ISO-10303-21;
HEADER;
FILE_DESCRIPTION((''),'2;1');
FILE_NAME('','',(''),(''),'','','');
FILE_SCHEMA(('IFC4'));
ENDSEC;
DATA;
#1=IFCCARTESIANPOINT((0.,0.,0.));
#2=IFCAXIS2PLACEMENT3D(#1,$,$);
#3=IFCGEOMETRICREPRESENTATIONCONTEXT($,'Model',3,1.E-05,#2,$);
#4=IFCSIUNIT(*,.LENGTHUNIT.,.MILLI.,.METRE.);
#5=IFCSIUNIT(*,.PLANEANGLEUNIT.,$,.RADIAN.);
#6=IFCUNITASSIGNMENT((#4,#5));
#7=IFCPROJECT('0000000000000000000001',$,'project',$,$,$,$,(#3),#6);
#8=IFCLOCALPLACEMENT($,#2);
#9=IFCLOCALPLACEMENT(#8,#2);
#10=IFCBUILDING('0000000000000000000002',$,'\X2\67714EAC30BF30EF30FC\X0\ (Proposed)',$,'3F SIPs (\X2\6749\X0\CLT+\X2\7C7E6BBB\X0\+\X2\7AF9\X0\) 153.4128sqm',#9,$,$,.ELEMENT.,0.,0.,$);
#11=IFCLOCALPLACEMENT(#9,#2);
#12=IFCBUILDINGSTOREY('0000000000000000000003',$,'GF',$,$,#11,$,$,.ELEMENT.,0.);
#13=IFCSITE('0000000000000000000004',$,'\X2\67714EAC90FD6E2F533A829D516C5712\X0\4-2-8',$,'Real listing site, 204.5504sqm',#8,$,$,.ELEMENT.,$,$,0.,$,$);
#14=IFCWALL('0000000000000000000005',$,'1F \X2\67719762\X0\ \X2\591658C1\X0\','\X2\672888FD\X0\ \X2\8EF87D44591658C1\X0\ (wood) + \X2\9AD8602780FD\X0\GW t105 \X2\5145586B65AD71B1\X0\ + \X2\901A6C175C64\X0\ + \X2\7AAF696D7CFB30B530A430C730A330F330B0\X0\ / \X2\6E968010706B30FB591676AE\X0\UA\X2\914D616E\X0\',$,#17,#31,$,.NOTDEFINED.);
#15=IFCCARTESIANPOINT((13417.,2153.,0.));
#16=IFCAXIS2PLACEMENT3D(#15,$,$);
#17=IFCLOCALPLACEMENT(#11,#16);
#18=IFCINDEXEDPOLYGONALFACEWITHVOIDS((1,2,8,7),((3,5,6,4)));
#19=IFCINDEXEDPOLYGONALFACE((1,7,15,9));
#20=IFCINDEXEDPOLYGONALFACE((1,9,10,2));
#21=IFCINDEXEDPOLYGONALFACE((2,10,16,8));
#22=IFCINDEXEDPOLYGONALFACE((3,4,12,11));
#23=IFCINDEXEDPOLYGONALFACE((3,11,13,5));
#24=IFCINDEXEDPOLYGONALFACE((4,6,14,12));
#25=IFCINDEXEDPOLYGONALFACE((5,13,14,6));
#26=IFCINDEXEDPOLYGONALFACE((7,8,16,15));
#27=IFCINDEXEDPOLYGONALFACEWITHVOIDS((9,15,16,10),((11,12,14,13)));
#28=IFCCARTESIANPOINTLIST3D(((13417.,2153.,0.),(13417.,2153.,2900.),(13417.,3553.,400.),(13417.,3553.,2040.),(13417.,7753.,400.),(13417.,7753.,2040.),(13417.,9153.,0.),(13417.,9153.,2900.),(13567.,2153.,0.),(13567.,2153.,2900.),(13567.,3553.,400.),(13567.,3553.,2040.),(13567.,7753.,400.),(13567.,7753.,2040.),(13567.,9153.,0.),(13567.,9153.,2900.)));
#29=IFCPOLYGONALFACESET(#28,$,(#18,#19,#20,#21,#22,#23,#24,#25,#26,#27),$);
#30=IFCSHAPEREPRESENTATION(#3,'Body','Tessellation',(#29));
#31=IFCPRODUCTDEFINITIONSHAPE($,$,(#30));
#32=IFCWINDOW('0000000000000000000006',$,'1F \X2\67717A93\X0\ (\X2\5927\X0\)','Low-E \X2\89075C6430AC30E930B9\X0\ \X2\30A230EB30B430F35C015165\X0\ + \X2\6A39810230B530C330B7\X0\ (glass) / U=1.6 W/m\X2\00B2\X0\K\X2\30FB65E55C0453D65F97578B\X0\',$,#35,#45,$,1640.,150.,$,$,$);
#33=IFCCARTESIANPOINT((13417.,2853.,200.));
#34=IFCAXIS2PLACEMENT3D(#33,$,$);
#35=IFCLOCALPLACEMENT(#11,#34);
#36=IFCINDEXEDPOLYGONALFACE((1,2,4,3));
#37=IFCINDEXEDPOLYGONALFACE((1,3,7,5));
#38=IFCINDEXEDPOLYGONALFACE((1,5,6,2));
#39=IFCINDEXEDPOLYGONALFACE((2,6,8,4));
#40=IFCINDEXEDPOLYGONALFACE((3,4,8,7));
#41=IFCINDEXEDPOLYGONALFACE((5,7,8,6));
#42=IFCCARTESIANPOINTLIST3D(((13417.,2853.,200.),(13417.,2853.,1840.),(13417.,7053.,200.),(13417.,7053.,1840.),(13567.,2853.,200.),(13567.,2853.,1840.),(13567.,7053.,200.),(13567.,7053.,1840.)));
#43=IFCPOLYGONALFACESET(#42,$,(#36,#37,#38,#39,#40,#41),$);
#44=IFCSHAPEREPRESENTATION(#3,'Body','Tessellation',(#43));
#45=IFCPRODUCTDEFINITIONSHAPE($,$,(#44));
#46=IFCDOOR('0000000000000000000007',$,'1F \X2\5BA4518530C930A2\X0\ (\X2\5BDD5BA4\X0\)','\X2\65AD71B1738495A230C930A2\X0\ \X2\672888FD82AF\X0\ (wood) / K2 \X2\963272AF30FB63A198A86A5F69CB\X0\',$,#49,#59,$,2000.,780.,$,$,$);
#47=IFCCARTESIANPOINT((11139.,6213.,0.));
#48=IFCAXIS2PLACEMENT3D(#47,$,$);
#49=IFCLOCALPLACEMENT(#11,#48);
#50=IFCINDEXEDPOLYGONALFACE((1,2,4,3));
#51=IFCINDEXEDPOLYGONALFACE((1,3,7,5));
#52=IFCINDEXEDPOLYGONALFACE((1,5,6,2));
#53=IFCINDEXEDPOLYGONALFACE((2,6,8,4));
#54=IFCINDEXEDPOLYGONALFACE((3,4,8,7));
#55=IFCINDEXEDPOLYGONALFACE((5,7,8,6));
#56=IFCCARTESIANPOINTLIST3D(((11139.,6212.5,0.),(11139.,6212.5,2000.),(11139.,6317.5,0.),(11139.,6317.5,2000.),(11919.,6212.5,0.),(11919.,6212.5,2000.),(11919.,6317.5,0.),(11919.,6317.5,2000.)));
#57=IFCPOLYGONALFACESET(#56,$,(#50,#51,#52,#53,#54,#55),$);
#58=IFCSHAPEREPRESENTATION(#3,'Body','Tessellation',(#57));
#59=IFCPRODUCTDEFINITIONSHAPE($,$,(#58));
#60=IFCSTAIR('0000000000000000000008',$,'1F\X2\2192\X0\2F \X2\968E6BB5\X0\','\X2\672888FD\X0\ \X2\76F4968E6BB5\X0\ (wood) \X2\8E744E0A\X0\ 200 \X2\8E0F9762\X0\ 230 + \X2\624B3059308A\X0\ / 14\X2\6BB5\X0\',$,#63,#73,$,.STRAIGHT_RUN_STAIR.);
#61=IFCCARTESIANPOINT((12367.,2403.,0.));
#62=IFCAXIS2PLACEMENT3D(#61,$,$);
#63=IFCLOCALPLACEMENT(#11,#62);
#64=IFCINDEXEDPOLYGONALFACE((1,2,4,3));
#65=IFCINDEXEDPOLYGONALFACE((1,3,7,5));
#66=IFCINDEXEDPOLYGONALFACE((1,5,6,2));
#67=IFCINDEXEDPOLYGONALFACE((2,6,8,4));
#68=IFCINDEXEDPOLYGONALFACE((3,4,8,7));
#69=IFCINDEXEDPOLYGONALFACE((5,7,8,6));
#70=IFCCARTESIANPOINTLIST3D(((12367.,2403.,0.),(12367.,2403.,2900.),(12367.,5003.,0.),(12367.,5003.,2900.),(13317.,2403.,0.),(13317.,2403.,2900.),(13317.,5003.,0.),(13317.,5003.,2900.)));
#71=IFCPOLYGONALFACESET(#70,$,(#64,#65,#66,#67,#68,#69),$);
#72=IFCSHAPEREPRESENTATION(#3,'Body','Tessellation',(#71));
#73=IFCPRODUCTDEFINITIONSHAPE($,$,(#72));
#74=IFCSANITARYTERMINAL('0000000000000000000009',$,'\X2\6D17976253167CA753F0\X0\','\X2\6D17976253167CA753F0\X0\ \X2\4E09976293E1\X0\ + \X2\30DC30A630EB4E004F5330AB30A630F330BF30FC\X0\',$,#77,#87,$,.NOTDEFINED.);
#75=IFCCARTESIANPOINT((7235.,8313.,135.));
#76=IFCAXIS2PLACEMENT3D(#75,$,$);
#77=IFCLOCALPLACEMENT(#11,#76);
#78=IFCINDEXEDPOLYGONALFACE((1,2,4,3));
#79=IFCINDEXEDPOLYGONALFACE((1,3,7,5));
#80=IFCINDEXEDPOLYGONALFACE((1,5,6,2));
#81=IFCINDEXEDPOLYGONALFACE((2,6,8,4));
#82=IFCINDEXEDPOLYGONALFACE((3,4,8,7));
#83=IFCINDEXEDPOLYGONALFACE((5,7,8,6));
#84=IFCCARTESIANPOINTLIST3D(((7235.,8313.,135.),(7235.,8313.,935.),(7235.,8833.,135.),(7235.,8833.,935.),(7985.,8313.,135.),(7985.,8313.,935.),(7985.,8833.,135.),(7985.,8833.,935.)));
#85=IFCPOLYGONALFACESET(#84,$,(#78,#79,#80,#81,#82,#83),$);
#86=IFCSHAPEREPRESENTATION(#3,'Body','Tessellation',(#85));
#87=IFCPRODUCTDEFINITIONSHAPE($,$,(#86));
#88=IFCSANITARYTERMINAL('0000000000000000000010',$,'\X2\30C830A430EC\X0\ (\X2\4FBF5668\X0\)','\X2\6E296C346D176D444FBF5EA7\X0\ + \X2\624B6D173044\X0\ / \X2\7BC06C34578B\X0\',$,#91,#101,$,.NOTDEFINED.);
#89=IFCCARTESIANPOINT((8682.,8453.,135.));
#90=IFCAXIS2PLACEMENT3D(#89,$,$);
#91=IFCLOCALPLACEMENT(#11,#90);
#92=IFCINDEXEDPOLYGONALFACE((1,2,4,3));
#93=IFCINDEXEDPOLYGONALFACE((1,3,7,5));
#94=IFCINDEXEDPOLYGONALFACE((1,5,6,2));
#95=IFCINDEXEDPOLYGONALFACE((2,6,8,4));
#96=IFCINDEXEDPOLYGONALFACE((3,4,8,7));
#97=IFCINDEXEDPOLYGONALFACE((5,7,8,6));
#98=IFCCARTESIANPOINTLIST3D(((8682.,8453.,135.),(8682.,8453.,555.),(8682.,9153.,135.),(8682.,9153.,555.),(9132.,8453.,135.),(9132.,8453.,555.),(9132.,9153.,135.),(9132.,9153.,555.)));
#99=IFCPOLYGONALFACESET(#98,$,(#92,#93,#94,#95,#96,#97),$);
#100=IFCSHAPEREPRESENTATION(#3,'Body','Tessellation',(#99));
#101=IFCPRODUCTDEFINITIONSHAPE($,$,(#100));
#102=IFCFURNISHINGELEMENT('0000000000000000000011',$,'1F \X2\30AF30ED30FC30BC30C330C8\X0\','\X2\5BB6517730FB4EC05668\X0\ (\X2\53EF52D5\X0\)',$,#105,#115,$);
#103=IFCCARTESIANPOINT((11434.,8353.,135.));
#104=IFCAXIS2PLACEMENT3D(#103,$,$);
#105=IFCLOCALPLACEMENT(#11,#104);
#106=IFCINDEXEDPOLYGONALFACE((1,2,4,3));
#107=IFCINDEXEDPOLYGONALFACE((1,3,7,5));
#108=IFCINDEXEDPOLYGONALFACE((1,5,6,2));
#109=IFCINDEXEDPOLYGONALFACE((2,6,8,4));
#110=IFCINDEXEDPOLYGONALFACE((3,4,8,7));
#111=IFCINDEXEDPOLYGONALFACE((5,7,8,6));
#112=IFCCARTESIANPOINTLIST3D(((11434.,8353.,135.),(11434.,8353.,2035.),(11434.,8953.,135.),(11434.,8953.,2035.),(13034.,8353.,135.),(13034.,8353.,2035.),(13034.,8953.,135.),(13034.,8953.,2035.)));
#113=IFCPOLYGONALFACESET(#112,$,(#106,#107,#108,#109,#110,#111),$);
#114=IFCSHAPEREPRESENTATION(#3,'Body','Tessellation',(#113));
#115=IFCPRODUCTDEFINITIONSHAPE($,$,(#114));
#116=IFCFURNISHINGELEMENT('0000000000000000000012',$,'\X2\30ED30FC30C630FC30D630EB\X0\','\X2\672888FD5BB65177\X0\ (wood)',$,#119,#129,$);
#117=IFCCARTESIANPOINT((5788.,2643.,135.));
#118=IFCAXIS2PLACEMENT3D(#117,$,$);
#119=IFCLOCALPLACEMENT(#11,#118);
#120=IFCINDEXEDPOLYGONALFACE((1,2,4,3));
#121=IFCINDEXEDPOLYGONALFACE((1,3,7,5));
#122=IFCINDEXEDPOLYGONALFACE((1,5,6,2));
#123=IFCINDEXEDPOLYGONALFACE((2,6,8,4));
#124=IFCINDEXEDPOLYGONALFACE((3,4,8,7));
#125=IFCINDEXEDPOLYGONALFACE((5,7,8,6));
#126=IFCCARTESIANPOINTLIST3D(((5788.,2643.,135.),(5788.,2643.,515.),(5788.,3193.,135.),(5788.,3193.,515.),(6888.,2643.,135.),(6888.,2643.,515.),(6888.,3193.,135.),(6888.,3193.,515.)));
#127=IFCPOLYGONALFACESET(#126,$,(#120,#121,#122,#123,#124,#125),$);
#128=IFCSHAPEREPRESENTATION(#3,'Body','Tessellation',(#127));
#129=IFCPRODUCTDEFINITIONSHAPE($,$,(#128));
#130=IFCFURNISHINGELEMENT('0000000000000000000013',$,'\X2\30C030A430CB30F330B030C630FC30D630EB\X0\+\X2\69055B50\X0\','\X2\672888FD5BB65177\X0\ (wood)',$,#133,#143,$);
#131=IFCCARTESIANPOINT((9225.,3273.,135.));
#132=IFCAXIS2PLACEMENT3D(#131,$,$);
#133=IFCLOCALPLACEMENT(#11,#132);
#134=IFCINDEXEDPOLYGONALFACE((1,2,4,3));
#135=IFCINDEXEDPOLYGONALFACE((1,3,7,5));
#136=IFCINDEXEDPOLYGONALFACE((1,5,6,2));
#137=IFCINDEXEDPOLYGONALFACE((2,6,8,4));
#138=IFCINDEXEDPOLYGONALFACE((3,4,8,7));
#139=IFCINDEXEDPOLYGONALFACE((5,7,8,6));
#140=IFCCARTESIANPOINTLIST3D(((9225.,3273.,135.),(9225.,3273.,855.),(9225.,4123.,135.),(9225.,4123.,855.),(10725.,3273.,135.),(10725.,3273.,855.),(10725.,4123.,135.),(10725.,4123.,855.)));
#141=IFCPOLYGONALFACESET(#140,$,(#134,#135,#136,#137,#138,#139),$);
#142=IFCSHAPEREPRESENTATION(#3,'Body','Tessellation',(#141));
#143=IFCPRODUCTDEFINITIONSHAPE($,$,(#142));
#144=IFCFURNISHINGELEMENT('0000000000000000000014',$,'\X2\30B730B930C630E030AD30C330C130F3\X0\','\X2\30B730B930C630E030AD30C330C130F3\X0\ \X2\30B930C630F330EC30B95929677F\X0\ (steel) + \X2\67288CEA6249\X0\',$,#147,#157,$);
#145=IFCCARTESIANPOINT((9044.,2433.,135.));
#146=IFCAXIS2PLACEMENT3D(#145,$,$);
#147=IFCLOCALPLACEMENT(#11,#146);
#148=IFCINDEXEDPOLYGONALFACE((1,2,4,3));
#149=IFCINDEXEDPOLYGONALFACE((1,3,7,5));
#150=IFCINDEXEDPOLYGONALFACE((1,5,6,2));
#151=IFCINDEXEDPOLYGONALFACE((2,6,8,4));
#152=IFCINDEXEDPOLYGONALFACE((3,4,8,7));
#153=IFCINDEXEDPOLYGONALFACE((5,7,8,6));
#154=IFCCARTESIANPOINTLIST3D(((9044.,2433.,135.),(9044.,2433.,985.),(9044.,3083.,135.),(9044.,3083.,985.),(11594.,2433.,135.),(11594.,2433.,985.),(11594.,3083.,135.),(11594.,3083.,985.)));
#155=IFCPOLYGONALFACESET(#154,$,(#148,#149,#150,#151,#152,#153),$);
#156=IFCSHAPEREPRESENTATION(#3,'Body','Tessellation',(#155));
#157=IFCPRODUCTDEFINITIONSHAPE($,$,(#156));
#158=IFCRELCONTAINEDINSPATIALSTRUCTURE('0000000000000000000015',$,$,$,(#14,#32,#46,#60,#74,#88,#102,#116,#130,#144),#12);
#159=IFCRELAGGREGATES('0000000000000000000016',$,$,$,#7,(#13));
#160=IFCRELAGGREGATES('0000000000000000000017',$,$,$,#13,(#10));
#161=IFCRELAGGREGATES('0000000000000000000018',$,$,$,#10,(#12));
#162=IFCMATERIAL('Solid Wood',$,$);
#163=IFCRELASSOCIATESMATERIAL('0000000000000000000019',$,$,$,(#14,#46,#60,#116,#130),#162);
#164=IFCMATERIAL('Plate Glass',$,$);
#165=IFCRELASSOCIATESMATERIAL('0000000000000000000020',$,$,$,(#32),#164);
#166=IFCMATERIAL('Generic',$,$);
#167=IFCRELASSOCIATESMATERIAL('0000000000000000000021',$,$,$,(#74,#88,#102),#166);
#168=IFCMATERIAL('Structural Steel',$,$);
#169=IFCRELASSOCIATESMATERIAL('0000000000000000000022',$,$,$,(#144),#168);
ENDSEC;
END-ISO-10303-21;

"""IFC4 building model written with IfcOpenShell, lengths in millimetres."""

from ifc_helpers import new_model, si_unit, frame, frame_2d, origin, place, context, project, spatial, rectangle, extrude, material, element, fill, save


model = new_model("IFC4")

# Units and contexts
model_context = context("Model", 3, precision=1e-05, world=origin())
ifc_project = project(units=[si_unit("LENGTHUNIT", "METRE", prefix="MILLI"), si_unit("PLANEANGLEUNIT", "RADIAN")], contexts=[model_context])

# Site, building, storey
site_placement = place(None, origin())
site = spatial("IfcSite", under=ifc_project, at=site_placement, Name="東京都港区芝公園4-2-8", ObjectType="Real listing site, 204.5504sqm", CompositionType="ELEMENT", RefElevation=0.0)
building_placement = place(site_placement, origin())
building = spatial("IfcBuilding", under=site, at=building_placement, Name="東京タワー (Proposed)", ObjectType="3F SIPs (杉CLT+籾殻+竹) 153.4128sqm", CompositionType="ELEMENT", ElevationOfRefHeight=0.0, ElevationOfTerrain=0.0)
storey_placement = place(building_placement, origin())
storey = spatial("IfcBuildingStorey", under=building, at=storey_placement, Name="GF", CompositionType="ELEMENT", Elevation=0.0)

# Wall, opening, window
ifc_material_1 = material(Name="Solid Wood")
wall_1_placement = place(storey_placement, frame((13417.0, 2153.0, 0.0)))
wall_1 = element("IfcWall", 1, at=wall_1_placement, inside=storey, material=ifc_material_1, Name="1F 東面 外壁", Description="木製 軸組外壁 (wood) + 高性能GW t105 充填断熱 + 通気層 + 窯業系サイディング / 準耐火・外皮UA配慮", PredefinedType="NOTDEFINED", context=model_context, shape_type="SweptSolid", body=[
    extrude(rectangle(XDim=150.0, YDim=7000.0, at=frame_2d((75.0, 3500.0))), frame((13417.0, 2153.0, 0.0)), (0.0, 0.0, 1.0), 2900.0),
])
opening_placement = place(storey_placement, frame((13417.0, 2853.0, 200.0)))
opening = element("IfcOpeningElement", 2, at=opening_placement, cuts=wall_1, PredefinedType="NOTDEFINED", context=model_context, shape_type="SweptSolid", body=[
    extrude(rectangle(XDim=150.0, YDim=4200.0, at=frame_2d((75.0, 2100.0))), frame((13417.0, 2853.0, 200.0)), (0.0, 0.0, 1.0), 1640.0),
])
ifc_material_2 = material(Name="Plate Glass")
window_placement = place(storey_placement, frame((13417.0, 2853.0, 200.0)))
window = element("IfcWindow", 3, at=window_placement, inside=storey, material=ifc_material_2, Name="1F 東窓 (大)", Description="Low-E 複層ガラス アルゴン封入 + 樹脂サッシ (glass) / U=1.6 W/m²K・日射取得型", OverallHeight=1640.0, OverallWidth=150.0, context=model_context, shape_type="SweptSolid", body=[
    extrude(rectangle(XDim=150.0, YDim=4200.0, at=frame_2d((75.0, 2100.0))), frame((13417.0, 2853.0, 200.0)), (0.0, 0.0, 1.0), 1640.0),
])
fill(opening, window)

# Door
door_placement = place(storey_placement, frame((11139.0, 6213.0, 0.0)))
element("IfcDoor", 4, at=door_placement, inside=storey, material=ifc_material_1, Name="1F 室内ドア (寝室)", Description="断熱玄関ドア 木製芯 (wood) / K2 防犯・採風機構", OverallHeight=2000.0, OverallWidth=780.0, context=model_context, shape_type="SweptSolid", body=[
    extrude(rectangle(XDim=780.0, YDim=105.0, at=frame_2d((390.0, 52.0))), frame((11139.0, 6213.0, 0.0)), (0.0, 0.0, 1.0), 2000.0),
])

# Stair
stair_placement = place(storey_placement, frame((12367.0, 2403.0, 0.0)))
element("IfcStair", 5, at=stair_placement, inside=storey, material=ifc_material_1, Name="1F→2F 階段", Description="木製 直階段 (wood) 蹴上 200 踏面 230 + 手すり / 14段", PredefinedType="STRAIGHT_RUN_STAIR", context=model_context, shape_type="SweptSolid", body=[
    extrude(rectangle(XDim=950.0, YDim=2600.0, at=frame_2d((475.0, 1300.0))), frame((12367.0, 2403.0, 0.0)), (0.0, 0.0, 1.0), 2900.0),
])

# Sanitary terminals
ifc_material_3 = material(Name="Generic")
sanitary_terminal_1_placement = place(storey_placement, frame((7235.0, 8313.0, 135.0)))
element("IfcSanitaryTerminal", 6, at=sanitary_terminal_1_placement, inside=storey, material=ifc_material_3, Name="洗面化粧台", Description="洗面化粧台 三面鏡 + ボウル一体カウンター", PredefinedType="NOTDEFINED", context=model_context, shape_type="SweptSolid", body=[
    extrude(rectangle(XDim=750.0, YDim=520.0, at=frame_2d((375.0, 260.0))), frame((7235.0, 8313.0, 135.0)), (0.0, 0.0, 1.0), 800.0),
])
sanitary_terminal_2_placement = place(storey_placement, frame((8682.0, 8453.0, 135.0)))
element("IfcSanitaryTerminal", 7, at=sanitary_terminal_2_placement, inside=storey, material=ifc_material_3, Name="トイレ (便器)", Description="温水洗浄便座 + 手洗い / 節水型", PredefinedType="NOTDEFINED", context=model_context, shape_type="SweptSolid", body=[
    extrude(rectangle(XDim=450.0, YDim=700.0, at=frame_2d((225.0, 350.0))), frame((8682.0, 8453.0, 135.0)), (0.0, 0.0, 1.0), 420.0),
])

# Furnishing elements
furnishing_1_placement = place(storey_placement, frame((11434.0, 8353.0, 135.0)))
element("IfcFurnishingElement", 8, at=furnishing_1_placement, inside=storey, material=ifc_material_3, Name="1F クローゼット", Description="家具・什器 (可動)", context=model_context, shape_type="SweptSolid", body=[
    extrude(rectangle(XDim=1600.0, YDim=600.0, at=frame_2d((800.0, 300.0))), frame((11434.0, 8353.0, 135.0)), (0.0, 0.0, 1.0), 1900.0),
])
furnishing_2_placement = place(storey_placement, frame((5788.0, 2643.0, 135.0)))
element("IfcFurnishingElement", 9, at=furnishing_2_placement, inside=storey, material=ifc_material_1, Name="ローテーブル", Description="木製家具 (wood)", context=model_context, shape_type="SweptSolid", body=[
    extrude(rectangle(XDim=1100.0, YDim=550.0, at=frame_2d((550.0, 275.0))), frame((5788.0, 2643.0, 135.0)), (0.0, 0.0, 1.0), 380.0),
])
furnishing_3_placement = place(storey_placement, frame((9225.0, 3273.0, 135.0)))
element("IfcFurnishingElement", 10, at=furnishing_3_placement, inside=storey, material=ifc_material_1, Name="ダイニングテーブル+椅子", Description="木製家具 (wood)", context=model_context, shape_type="SweptSolid", body=[
    extrude(rectangle(XDim=1500.0, YDim=850.0, at=frame_2d((750.0, 425.0))), frame((9225.0, 3273.0, 135.0)), (0.0, 0.0, 1.0), 720.0),
])
ifc_material_4 = material(Name="Structural Steel")
furnishing_4_placement = place(storey_placement, frame((9044.0, 2433.0, 135.0)))
element("IfcFurnishingElement", 11, at=furnishing_4_placement, inside=storey, material=ifc_material_4, Name="システムキッチン", Description="システムキッチン ステンレス天板 (steel) + 木質扉", context=model_context, shape_type="SweptSolid", body=[
    extrude(rectangle(XDim=2550.0, YDim=650.0, at=frame_2d((1275.0, 325.0))), frame((9044.0, 2433.0, 135.0)), (0.0, 0.0, 1.0), 850.0),
])

save(model, "model.ifc")
